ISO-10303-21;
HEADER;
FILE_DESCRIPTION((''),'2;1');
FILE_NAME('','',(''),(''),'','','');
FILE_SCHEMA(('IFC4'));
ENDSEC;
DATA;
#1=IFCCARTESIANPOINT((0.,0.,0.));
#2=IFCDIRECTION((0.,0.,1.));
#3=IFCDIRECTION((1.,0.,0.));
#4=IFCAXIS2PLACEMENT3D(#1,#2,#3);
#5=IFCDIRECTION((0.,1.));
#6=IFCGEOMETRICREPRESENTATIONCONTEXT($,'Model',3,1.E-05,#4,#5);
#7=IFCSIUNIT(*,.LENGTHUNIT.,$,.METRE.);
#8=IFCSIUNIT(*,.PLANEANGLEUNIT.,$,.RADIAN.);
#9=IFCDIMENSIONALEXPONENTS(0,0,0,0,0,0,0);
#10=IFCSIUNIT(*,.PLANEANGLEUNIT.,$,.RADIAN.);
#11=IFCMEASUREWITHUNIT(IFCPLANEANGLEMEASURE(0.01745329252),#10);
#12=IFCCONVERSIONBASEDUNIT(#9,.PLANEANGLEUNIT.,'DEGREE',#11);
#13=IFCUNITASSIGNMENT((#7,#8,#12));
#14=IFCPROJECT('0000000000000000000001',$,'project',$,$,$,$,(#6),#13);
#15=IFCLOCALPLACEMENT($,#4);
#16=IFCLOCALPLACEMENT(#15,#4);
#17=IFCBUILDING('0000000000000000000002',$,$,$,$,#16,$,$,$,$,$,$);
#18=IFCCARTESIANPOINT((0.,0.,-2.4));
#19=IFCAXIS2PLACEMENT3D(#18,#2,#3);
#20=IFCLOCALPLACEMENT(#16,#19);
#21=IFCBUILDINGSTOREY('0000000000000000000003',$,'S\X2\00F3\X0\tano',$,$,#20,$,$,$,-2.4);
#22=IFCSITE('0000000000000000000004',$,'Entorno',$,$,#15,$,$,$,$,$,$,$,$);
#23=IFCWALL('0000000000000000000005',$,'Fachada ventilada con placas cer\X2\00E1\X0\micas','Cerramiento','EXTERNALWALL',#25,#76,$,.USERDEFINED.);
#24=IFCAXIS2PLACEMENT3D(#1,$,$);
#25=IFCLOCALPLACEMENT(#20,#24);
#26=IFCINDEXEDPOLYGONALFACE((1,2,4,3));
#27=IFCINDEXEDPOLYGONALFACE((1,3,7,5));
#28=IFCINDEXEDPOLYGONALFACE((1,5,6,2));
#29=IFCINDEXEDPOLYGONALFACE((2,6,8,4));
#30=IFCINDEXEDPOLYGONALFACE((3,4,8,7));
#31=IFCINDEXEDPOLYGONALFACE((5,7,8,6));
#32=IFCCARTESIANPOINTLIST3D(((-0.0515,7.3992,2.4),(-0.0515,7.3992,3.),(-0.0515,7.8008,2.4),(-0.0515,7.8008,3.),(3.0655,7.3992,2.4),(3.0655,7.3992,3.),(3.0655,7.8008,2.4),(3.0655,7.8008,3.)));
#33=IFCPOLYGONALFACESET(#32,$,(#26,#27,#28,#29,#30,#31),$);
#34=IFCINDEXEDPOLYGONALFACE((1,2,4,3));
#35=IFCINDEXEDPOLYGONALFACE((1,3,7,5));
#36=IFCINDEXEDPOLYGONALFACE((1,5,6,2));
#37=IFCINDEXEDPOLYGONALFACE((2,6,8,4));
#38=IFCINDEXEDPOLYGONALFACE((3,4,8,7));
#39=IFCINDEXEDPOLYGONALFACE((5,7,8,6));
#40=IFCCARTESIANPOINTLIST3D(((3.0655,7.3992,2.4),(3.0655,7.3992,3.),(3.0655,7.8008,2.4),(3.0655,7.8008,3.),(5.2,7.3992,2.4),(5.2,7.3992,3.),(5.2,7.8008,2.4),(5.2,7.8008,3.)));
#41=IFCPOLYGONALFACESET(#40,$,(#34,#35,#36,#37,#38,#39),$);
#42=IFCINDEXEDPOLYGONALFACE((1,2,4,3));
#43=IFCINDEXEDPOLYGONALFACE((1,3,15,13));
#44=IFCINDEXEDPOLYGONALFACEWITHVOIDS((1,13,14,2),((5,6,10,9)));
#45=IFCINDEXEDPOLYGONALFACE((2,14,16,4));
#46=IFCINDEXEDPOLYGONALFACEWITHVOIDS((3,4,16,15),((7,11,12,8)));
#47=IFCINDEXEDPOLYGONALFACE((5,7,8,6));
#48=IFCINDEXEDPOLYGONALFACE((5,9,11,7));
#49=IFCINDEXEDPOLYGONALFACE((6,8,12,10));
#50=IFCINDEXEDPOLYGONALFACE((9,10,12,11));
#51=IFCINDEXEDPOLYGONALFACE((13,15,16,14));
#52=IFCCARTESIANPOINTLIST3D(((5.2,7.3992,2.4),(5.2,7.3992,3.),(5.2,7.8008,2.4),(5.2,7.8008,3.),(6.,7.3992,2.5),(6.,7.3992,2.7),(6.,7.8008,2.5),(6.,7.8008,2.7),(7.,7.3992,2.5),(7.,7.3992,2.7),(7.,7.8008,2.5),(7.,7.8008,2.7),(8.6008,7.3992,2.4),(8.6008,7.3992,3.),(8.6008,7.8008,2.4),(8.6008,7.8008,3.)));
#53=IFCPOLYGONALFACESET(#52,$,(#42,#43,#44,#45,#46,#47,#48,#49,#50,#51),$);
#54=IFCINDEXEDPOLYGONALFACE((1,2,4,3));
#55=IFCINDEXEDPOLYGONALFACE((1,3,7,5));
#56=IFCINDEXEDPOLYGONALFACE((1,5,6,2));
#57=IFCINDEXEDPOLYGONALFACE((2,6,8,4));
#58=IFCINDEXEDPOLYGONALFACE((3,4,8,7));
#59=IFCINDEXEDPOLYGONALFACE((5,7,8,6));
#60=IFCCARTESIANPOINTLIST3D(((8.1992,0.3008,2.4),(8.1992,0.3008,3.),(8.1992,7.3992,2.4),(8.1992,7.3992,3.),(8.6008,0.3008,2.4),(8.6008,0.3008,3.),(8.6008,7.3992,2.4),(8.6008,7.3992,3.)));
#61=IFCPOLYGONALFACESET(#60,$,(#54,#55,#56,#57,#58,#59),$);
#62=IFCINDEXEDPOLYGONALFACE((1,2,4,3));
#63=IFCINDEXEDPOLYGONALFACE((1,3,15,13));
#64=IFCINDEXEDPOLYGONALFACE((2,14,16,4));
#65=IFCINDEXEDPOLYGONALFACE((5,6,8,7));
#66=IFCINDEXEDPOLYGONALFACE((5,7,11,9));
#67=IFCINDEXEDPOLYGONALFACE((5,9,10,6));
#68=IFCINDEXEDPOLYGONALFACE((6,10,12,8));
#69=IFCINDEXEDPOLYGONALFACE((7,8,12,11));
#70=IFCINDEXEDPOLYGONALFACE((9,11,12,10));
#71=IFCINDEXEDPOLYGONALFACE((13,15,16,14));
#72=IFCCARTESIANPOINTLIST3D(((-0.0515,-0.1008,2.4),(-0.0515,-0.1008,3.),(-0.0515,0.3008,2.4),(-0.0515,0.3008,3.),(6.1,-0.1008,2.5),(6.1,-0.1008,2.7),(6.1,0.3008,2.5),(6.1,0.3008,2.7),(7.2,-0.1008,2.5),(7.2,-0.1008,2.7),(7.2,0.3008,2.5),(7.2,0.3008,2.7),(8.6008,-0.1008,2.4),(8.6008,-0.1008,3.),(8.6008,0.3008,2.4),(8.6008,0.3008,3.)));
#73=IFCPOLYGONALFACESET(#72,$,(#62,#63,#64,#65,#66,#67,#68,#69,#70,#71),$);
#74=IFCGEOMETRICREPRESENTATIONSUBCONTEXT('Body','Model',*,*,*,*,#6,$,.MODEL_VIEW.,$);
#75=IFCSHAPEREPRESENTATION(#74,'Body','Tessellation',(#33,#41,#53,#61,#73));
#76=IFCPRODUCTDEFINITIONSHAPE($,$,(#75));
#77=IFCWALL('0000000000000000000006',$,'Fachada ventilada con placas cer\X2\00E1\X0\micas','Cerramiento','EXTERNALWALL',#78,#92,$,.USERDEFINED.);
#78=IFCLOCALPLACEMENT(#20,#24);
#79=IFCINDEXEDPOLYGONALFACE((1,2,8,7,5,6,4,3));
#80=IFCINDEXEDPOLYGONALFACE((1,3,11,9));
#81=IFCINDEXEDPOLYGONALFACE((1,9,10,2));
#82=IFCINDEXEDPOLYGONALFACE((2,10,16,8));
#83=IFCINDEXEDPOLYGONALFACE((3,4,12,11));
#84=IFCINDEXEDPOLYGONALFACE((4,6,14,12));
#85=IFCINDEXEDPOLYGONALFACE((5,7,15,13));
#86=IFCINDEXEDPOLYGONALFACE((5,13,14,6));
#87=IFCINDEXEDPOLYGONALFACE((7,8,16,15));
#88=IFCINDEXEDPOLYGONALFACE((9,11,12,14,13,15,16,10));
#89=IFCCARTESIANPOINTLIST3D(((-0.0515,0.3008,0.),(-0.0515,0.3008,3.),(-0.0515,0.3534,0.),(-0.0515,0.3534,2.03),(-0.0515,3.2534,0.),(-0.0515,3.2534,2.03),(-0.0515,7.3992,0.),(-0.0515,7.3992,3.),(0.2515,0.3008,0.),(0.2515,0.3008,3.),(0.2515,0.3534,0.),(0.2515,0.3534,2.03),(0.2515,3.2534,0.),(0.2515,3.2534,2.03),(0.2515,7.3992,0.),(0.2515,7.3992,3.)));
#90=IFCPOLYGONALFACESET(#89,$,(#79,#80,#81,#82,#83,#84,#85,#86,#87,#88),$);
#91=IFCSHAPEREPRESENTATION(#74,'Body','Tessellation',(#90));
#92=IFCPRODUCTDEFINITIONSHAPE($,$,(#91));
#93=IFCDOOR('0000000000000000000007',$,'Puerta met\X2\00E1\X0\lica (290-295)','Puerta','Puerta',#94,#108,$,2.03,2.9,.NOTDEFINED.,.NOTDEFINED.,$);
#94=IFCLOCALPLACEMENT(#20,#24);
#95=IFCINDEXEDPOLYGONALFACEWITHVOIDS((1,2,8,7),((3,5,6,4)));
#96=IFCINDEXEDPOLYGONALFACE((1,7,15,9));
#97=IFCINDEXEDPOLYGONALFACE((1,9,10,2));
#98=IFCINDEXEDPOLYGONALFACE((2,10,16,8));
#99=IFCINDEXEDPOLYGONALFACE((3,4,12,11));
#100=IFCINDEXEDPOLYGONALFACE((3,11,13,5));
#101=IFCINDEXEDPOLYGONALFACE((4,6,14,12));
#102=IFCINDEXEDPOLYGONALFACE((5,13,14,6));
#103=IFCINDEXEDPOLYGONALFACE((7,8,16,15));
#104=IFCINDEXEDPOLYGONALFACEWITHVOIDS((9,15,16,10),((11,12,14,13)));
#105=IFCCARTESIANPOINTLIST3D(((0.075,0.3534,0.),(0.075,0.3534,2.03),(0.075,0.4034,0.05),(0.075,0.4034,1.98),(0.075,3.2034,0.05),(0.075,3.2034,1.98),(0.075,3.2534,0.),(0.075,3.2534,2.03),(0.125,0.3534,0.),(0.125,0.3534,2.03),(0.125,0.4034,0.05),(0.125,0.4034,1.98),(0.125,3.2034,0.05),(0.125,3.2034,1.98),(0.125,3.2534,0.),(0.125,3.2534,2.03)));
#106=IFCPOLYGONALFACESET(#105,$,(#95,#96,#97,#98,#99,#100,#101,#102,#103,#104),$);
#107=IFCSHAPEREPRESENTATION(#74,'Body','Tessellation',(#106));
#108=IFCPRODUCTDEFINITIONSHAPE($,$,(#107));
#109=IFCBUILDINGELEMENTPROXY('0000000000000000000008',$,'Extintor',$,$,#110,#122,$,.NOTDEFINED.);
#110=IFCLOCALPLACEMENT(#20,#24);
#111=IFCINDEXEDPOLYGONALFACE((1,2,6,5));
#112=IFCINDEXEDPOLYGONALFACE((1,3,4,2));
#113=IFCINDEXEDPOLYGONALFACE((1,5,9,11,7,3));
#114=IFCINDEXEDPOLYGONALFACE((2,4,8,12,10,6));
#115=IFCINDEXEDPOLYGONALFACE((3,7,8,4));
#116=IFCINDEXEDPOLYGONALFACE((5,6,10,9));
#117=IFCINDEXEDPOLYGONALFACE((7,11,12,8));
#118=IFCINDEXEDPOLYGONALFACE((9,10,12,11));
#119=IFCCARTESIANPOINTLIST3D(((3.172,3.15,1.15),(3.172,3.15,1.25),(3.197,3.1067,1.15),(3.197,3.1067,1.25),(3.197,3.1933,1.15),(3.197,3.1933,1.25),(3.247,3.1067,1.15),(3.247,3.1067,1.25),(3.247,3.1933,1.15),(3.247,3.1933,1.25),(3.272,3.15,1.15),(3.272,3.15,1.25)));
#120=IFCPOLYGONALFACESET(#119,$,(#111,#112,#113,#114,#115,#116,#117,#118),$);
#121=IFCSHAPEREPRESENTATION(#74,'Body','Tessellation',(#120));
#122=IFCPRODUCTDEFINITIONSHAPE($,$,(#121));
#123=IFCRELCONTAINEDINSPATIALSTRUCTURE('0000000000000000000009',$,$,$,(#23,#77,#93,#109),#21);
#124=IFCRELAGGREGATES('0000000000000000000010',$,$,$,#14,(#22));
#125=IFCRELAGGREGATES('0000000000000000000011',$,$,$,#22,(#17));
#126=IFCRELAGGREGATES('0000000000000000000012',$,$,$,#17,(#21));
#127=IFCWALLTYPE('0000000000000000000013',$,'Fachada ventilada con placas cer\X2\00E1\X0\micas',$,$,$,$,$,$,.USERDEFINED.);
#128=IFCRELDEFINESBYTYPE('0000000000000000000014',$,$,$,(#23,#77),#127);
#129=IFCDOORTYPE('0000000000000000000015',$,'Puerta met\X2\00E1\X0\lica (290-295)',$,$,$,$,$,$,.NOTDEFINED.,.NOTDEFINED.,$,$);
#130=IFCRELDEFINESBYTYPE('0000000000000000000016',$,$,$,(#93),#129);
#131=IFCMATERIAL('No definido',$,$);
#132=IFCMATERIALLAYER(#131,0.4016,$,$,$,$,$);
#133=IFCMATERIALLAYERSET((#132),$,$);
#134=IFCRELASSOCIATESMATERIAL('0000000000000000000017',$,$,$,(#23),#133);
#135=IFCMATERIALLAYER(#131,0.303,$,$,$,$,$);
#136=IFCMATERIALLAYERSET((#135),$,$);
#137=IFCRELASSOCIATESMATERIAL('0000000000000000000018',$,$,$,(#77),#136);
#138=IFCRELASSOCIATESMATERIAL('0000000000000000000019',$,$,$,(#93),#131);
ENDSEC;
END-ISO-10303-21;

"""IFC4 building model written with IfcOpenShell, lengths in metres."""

from ifc_helpers import new_model, entity, si_unit, converted_unit, direction, frame, origin_with_axes, origin_2d_with_axis, place, context, subcontext, project, spatial, polyline, rectangle, hollow_rectangle, outline, extrude, shape, source, transform, mapped, material, layer, layer_set, layer_usage, type_object, element, fill, save


model = new_model("IFC4")

# Units and contexts
model_context = context("Model", 3, precision=1e-05, world=origin_with_axes(), true_north=direction((0.0, 1.0)))
body_context = subcontext(model_context, "Body", "Model", "MODEL_VIEW")
footprint_context = subcontext(model_context, "FootPrint", "Model", "MODEL_VIEW")
ifc_project = project(units=[si_unit("LENGTHUNIT", "METRE"), si_unit("PLANEANGLEUNIT", "RADIAN"), converted_unit("PLANEANGLEUNIT", "DEGREE", entity("IfcPlaneAngleMeasure", 0.01745329252), si_unit("PLANEANGLEUNIT", "RADIAN"), dimensions=[0, 0, 0, 0, 0, 0, 0])], contexts=[model_context])

# Site, building, storey
site_placement = place(None, origin_with_axes())
site = spatial("IfcSite", under=ifc_project, at=site_placement, Name="Entorno")
building_placement = place(site_placement, origin_with_axes())
building = spatial("IfcBuilding", under=site, at=building_placement)
storey_placement = place(building_placement, frame((0.0, 0.0, -2.4), z_axis=(0.0, 0.0, 1.0), x_axis=(1.0, 0.0, 0.0)))
storey = spatial("IfcBuildingStorey", under=building, at=storey_placement, Name="Sótano", Elevation=-2.4)

# Shared definitions
ifc_material = material(Name="No definido")

# Wall, openings
ifc_layer_1 = layer(ifc_material, 0.4016)
ifc_layer_set_1 = layer_set([ifc_layer_1])
ifc_layer_usage_1 = layer_usage(ifc_layer_set_1, "AXIS2", "POSITIVE", -0.2008)
wall_type_1 = type_object("IfcWallType", Name="Fachada ventilada con placas cerámicas", PredefinedType="USERDEFINED")
wall_1_placement = place(storey_placement, frame((0.1, 7.6, 0.0), z_axis=(0.0, 0.0, 1.0), x_axis=(1.0, 0.0, 0.0)))
cartesian_point_1 = entity("IfcCartesianPoint", [-1.5585, -0.3])
cartesian_point_2 = entity("IfcCartesianPoint", [-1.5585, -0.3])
cartesian_point_3 = entity("IfcCartesianPoint", [-1.0673, -0.3])
cartesian_point_4 = entity("IfcCartesianPoint", [-1.0673, -0.3])
cartesian_point_5 = entity("IfcCartesianPoint", [-1.7004, -0.3])
cartesian_point_6 = entity("IfcCartesianPoint", [-1.7004, -0.3])
cartesian_point_7 = entity("IfcCartesianPoint", [-3.5492, -0.3])
cartesian_point_8 = entity("IfcCartesianPoint", [-3.5492, -0.3])
cartesian_point_9 = entity("IfcCartesianPoint", [-4.3262, -0.3])
cartesian_point_10 = entity("IfcCartesianPoint", [-4.3262, -0.3])
wall_1 = element("IfcWall", 1, at=wall_1_placement, inside=storey, type_object=wall_type_1, material=ifc_layer_usage_1, Name="Fachada ventilada con placas cerámicas", Description="Cerramiento", ObjectType="EXTERNALWALL", PredefinedType="USERDEFINED", context=body_context, shape_type="SolidModel", body=[
    entity("IfcExtrudedAreaSolidTapered", entity("IfcArbitraryClosedProfileDef", "AREA", None, entity("IfcPolyline", [cartesian_point_1, entity("IfcCartesianPoint", [1.5585, -0.3]), entity("IfcCartesianPoint", [1.5585, 0.3]), entity("IfcCartesianPoint", [-1.5585, 0.3]), cartesian_point_1])), entity("IfcAxis2Placement3D", entity("IfcCartesianPoint", [1.407, 0.2008, 2.7]), entity("IfcDirection", [0.0, -1.0, 0.0]), entity("IfcDirection", [1.0, 0.0, 0.0])), entity("IfcDirection", [0.0, 0.0, 1.0]), 0.4016, entity("IfcArbitraryClosedProfileDef", "AREA", None, entity("IfcPolyline", [cartesian_point_2, entity("IfcCartesianPoint", [1.5585, -0.3]), entity("IfcCartesianPoint", [1.5585, 0.3]), entity("IfcCartesianPoint", [-1.5585, 0.3]), cartesian_point_2]))),
    entity("IfcExtrudedAreaSolidTapered", entity("IfcArbitraryClosedProfileDef", "AREA", None, entity("IfcPolyline", [cartesian_point_3, entity("IfcCartesianPoint", [1.0673, -0.3]), entity("IfcCartesianPoint", [1.0673, 0.3]), entity("IfcCartesianPoint", [-1.0673, 0.3]), cartesian_point_3])), entity("IfcAxis2Placement3D", entity("IfcCartesianPoint", [4.0328, 0.2008, 2.7]), entity("IfcDirection", [0.0, -1.0, 0.0]), entity("IfcDirection", [1.0, 0.0, 0.0])), entity("IfcDirection", [0.0, 0.0, 1.0]), 0.4016, entity("IfcArbitraryClosedProfileDef", "AREA", None, entity("IfcPolyline", [cartesian_point_4, entity("IfcCartesianPoint", [1.0673, -0.3]), entity("IfcCartesianPoint", [1.0673, 0.3]), entity("IfcCartesianPoint", [-1.0673, 0.3]), cartesian_point_4]))),
    entity("IfcExtrudedAreaSolidTapered", entity("IfcArbitraryClosedProfileDef", "AREA", None, entity("IfcPolyline", [cartesian_point_5, entity("IfcCartesianPoint", [1.7004, -0.3]), entity("IfcCartesianPoint", [1.7004, 0.3]), entity("IfcCartesianPoint", [-1.7004, 0.3]), cartesian_point_5])), entity("IfcAxis2Placement3D", entity("IfcCartesianPoint", [6.8004, 0.2008, 2.7]), entity("IfcDirection", [0.0, -1.0, 0.0]), entity("IfcDirection", [1.0, 0.0, 0.0])), entity("IfcDirection", [0.0, 0.0, 1.0]), 0.4016, entity("IfcArbitraryClosedProfileDef", "AREA", None, entity("IfcPolyline", [cartesian_point_6, entity("IfcCartesianPoint", [1.7004, -0.3]), entity("IfcCartesianPoint", [1.7004, 0.3]), entity("IfcCartesianPoint", [-1.7004, 0.3]), cartesian_point_6]))),
    entity("IfcExtrudedAreaSolidTapered", entity("IfcArbitraryClosedProfileDef", "AREA", None, entity("IfcPolyline", [cartesian_point_7, entity("IfcCartesianPoint", [3.5492, -0.3]), entity("IfcCartesianPoint", [3.5492, 0.3]), entity("IfcCartesianPoint", [-3.5492, 0.3]), cartesian_point_7])), entity("IfcAxis2Placement3D", entity("IfcCartesianPoint", [8.5008, -3.75, 2.7]), entity("IfcDirection", [-1.0, 0.0, 0.0]), entity("IfcDirection", [0.0, -1.0, 0.0])), entity("IfcDirection", [0.0, 0.0, 1.0]), 0.4016, entity("IfcArbitraryClosedProfileDef", "AREA", None, entity("IfcPolyline", [cartesian_point_8, entity("IfcCartesianPoint", [3.5492, -0.3]), entity("IfcCartesianPoint", [3.5492, 0.3]), entity("IfcCartesianPoint", [-3.5492, 0.3]), cartesian_point_8]))),
    entity("IfcExtrudedAreaSolidTapered", entity("IfcArbitraryClosedProfileDef", "AREA", None, entity("IfcPolyline", [cartesian_point_9, entity("IfcCartesianPoint", [4.3262, -0.3]), entity("IfcCartesianPoint", [4.3262, 0.3]), entity("IfcCartesianPoint", [-4.3262, 0.3]), cartesian_point_9])), entity("IfcAxis2Placement3D", entity("IfcCartesianPoint", [4.1746, -7.7008, 2.7]), entity("IfcDirection", [0.0, 1.0, 0.0]), entity("IfcDirection", [-1.0, 0.0, 0.0])), entity("IfcDirection", [0.0, 0.0, 1.0]), 0.4016, entity("IfcArbitraryClosedProfileDef", "AREA", None, entity("IfcPolyline", [cartesian_point_10, entity("IfcCartesianPoint", [4.3262, -0.3]), entity("IfcCartesianPoint", [4.3262, 0.3]), entity("IfcCartesianPoint", [-4.3262, 0.3]), cartesian_point_10]))),
])
opening_1_placement = place(wall_1_placement, frame((6.4, 0.0, 2.6), z_axis=(0.0, 0.0, 1.0), x_axis=(1.0, 0.0, 0.0)))
cartesian_point_11 = entity("IfcCartesianPoint", [-0.5, -0.2008])
element("IfcOpeningElement", 2, at=opening_1_placement, cuts=wall_1, ObjectType="No definido", PredefinedType="OPENING", shapes=[
    shape(body_context, "Body", "SweptSolid", [extrude(rectangle(XDim=0.2, YDim=1.0, at=origin_2d_with_axis()), frame((0.0, -0.2008, 0.0), z_axis=(0.0, 1.0, 0.0), x_axis=(0.0, 0.0, 1.0)), (0.0, 0.0, 1.0), 0.4016)]),
    shape(footprint_context, "FootPrint", "GeometricCurveSet", [entity("IfcGeometricCurveSet", [entity("IfcPolyline", [cartesian_point_11, entity("IfcCartesianPoint", [0.5, -0.2008]), entity("IfcCartesianPoint", [0.5, 0.2008]), entity("IfcCartesianPoint", [-0.5, 0.2008]), cartesian_point_11])])]),
])
opening_2_placement = place(wall_1_placement, frame((6.55, -7.5, 2.6), z_axis=(0.0, 0.0, 1.0), x_axis=(-1.0, 0.0, 0.0)))
cartesian_point_12 = entity("IfcCartesianPoint", [-0.55, -0.2008])
element("IfcOpeningElement", 3, at=opening_2_placement, cuts=wall_1, ObjectType="No definido", PredefinedType="OPENING", shapes=[
    shape(body_context, "Body", "SweptSolid", [extrude(rectangle(XDim=0.2, YDim=1.1, at=origin_2d_with_axis()), frame((0.0, -0.2008, 0.0), z_axis=(0.0, 1.0, 0.0), x_axis=(0.0, 0.0, 1.0)), (0.0, 0.0, 1.0), 0.4016)]),
    shape(footprint_context, "FootPrint", "GeometricCurveSet", [entity("IfcGeometricCurveSet", [entity("IfcPolyline", [cartesian_point_12, entity("IfcCartesianPoint", [0.55, -0.2008]), entity("IfcCartesianPoint", [0.55, 0.2008]), entity("IfcCartesianPoint", [-0.55, 0.2008]), cartesian_point_12])])]),
])

# Wall, opening, door
ifc_layer_2 = layer(ifc_material, 0.303)
ifc_layer_set_2 = layer_set([ifc_layer_2])
ifc_layer_usage_2 = layer_usage(ifc_layer_set_2, "AXIS2", "POSITIVE", -0.1515)
wall_2_placement = place(storey_placement, frame((0.1, 0.1, 0.0), z_axis=(0.0, 0.0, 1.0), x_axis=(0.0, 1.0, 0.0)))
cartesian_point_13 = entity("IfcCartesianPoint", [-3.5492, -1.5])
cartesian_point_14 = entity("IfcCartesianPoint", [-3.5492, -1.5])
wall_2 = element("IfcWall", 4, at=wall_2_placement, inside=storey, type_object=wall_type_1, material=ifc_layer_usage_2, Name="Fachada ventilada con placas cerámicas", Description="Cerramiento", ObjectType="EXTERNALWALL", PredefinedType="USERDEFINED", context=body_context, shape_type="SolidModel", body=[
    entity("IfcExtrudedAreaSolidTapered", entity("IfcArbitraryClosedProfileDef", "AREA", None, entity("IfcPolyline", [cartesian_point_13, entity("IfcCartesianPoint", [3.5492, -1.5]), entity("IfcCartesianPoint", [3.5492, 1.5]), entity("IfcCartesianPoint", [-3.5492, 1.5]), cartesian_point_13])), entity("IfcAxis2Placement3D", entity("IfcCartesianPoint", [3.75, 0.1515, 1.5]), entity("IfcDirection", [0.0, -1.0, 0.0]), entity("IfcDirection", [1.0, 0.0, 0.0])), entity("IfcDirection", [0.0, 0.0, 1.0]), 0.303, entity("IfcArbitraryClosedProfileDef", "AREA", None, entity("IfcPolyline", [cartesian_point_14, entity("IfcCartesianPoint", [3.5492, -1.5]), entity("IfcCartesianPoint", [3.5492, 1.5]), entity("IfcCartesianPoint", [-3.5492, 1.5]), cartesian_point_14]))),
])
opening_3_placement = place(wall_2_placement, frame((1.7034, 0.0, 1.015), z_axis=(0.0, 0.0, 1.0), x_axis=(1.0, 0.0, 0.0)))
cartesian_point_15 = entity("IfcCartesianPoint", [-1.45, -0.1515])
opening_3 = element("IfcOpeningElement", 5, at=opening_3_placement, cuts=wall_2, ObjectType="No definido", PredefinedType="OPENING", shapes=[
    shape(body_context, "Body", "SweptSolid", [extrude(rectangle(XDim=2.03, YDim=2.9, at=origin_2d_with_axis()), frame((0.0, -0.1515, 0.0), z_axis=(0.0, 1.0, 0.0), x_axis=(0.0, 0.0, 1.0)), (0.0, 0.0, 1.0), 0.303)]),
    shape(footprint_context, "FootPrint", "GeometricCurveSet", [entity("IfcGeometricCurveSet", [entity("IfcPolyline", [cartesian_point_15, entity("IfcCartesianPoint", [1.45, -0.1515]), entity("IfcCartesianPoint", [1.45, 0.1515]), entity("IfcCartesianPoint", [-1.45, 0.1515]), cartesian_point_15])])]),
])
door_type_1 = type_object("IfcDoorType", Name="Puerta metálica (290-295)", OperationType="NOTDEFINED", PredefinedType="NOTDEFINED")
door_1_placement = place(opening_3_placement, origin_with_axes())
door_1 = element("IfcDoor", 6, at=door_1_placement, inside=storey, type_object=door_type_1, material=ifc_material, Name="Puerta metálica (290-295)", Description="Puerta", ObjectType="Puerta", OperationType="NOTDEFINED", OverallHeight=2.03, OverallWidth=2.9, PredefinedType="NOTDEFINED", context=body_context, shape_type="SweptSolid", body=[
    extrude(hollow_rectangle(XDim=2.9, YDim=2.03, WallThickness=0.05, InnerFilletRadius=0.0, OuterFilletRadius=0.0, at=origin_2d_with_axis()), frame((0.0, 0.025, 0.0), z_axis=(0.0, -1.0, 0.0), x_axis=(1.0, 0.0, 0.0)), (0.0, 0.0, 1.0), 0.05),
])
fill(opening_3, door_1)

# Building element proxy
shared_shape_1 = source(origin_with_axes(), body_context, "Body", "SolidModel", [
    extrude(outline(polyline([(0.05, 0.0), (0.025, 0.0433), (-0.025, 0.0433), (-0.05, 0.0), (-0.025, -0.0433), (0.025, -0.0433), (0.05, 0.0)])), frame((0.0, 0.0, -0.05), z_axis=(0.0, 0.0, 1.0), x_axis=(1.0, 0.0, 0.0)), (0.0, 0.0, 1.0), 0.1),
])
proxy_1_placement = place(storey_placement, frame((0.0, 0.0, 2.4), z_axis=(0.0, 0.0, 1.0), x_axis=(1.0, 0.0, 0.0)))
element("IfcBuildingElementProxy", 7, at=proxy_1_placement, inside=storey, Name="Extintor", PredefinedType="NOTDEFINED", context=body_context, shape_type="Brep", body=[
    mapped(shared_shape_1, transform((3.222, 3.15, -1.2), x_axis=(1.0, 0.0, 0.0), y_axis=(0.0, 1.0, 0.0), z_axis=(0.0, 0.0, 1.0))),
])

save(model, "model.ifc")
